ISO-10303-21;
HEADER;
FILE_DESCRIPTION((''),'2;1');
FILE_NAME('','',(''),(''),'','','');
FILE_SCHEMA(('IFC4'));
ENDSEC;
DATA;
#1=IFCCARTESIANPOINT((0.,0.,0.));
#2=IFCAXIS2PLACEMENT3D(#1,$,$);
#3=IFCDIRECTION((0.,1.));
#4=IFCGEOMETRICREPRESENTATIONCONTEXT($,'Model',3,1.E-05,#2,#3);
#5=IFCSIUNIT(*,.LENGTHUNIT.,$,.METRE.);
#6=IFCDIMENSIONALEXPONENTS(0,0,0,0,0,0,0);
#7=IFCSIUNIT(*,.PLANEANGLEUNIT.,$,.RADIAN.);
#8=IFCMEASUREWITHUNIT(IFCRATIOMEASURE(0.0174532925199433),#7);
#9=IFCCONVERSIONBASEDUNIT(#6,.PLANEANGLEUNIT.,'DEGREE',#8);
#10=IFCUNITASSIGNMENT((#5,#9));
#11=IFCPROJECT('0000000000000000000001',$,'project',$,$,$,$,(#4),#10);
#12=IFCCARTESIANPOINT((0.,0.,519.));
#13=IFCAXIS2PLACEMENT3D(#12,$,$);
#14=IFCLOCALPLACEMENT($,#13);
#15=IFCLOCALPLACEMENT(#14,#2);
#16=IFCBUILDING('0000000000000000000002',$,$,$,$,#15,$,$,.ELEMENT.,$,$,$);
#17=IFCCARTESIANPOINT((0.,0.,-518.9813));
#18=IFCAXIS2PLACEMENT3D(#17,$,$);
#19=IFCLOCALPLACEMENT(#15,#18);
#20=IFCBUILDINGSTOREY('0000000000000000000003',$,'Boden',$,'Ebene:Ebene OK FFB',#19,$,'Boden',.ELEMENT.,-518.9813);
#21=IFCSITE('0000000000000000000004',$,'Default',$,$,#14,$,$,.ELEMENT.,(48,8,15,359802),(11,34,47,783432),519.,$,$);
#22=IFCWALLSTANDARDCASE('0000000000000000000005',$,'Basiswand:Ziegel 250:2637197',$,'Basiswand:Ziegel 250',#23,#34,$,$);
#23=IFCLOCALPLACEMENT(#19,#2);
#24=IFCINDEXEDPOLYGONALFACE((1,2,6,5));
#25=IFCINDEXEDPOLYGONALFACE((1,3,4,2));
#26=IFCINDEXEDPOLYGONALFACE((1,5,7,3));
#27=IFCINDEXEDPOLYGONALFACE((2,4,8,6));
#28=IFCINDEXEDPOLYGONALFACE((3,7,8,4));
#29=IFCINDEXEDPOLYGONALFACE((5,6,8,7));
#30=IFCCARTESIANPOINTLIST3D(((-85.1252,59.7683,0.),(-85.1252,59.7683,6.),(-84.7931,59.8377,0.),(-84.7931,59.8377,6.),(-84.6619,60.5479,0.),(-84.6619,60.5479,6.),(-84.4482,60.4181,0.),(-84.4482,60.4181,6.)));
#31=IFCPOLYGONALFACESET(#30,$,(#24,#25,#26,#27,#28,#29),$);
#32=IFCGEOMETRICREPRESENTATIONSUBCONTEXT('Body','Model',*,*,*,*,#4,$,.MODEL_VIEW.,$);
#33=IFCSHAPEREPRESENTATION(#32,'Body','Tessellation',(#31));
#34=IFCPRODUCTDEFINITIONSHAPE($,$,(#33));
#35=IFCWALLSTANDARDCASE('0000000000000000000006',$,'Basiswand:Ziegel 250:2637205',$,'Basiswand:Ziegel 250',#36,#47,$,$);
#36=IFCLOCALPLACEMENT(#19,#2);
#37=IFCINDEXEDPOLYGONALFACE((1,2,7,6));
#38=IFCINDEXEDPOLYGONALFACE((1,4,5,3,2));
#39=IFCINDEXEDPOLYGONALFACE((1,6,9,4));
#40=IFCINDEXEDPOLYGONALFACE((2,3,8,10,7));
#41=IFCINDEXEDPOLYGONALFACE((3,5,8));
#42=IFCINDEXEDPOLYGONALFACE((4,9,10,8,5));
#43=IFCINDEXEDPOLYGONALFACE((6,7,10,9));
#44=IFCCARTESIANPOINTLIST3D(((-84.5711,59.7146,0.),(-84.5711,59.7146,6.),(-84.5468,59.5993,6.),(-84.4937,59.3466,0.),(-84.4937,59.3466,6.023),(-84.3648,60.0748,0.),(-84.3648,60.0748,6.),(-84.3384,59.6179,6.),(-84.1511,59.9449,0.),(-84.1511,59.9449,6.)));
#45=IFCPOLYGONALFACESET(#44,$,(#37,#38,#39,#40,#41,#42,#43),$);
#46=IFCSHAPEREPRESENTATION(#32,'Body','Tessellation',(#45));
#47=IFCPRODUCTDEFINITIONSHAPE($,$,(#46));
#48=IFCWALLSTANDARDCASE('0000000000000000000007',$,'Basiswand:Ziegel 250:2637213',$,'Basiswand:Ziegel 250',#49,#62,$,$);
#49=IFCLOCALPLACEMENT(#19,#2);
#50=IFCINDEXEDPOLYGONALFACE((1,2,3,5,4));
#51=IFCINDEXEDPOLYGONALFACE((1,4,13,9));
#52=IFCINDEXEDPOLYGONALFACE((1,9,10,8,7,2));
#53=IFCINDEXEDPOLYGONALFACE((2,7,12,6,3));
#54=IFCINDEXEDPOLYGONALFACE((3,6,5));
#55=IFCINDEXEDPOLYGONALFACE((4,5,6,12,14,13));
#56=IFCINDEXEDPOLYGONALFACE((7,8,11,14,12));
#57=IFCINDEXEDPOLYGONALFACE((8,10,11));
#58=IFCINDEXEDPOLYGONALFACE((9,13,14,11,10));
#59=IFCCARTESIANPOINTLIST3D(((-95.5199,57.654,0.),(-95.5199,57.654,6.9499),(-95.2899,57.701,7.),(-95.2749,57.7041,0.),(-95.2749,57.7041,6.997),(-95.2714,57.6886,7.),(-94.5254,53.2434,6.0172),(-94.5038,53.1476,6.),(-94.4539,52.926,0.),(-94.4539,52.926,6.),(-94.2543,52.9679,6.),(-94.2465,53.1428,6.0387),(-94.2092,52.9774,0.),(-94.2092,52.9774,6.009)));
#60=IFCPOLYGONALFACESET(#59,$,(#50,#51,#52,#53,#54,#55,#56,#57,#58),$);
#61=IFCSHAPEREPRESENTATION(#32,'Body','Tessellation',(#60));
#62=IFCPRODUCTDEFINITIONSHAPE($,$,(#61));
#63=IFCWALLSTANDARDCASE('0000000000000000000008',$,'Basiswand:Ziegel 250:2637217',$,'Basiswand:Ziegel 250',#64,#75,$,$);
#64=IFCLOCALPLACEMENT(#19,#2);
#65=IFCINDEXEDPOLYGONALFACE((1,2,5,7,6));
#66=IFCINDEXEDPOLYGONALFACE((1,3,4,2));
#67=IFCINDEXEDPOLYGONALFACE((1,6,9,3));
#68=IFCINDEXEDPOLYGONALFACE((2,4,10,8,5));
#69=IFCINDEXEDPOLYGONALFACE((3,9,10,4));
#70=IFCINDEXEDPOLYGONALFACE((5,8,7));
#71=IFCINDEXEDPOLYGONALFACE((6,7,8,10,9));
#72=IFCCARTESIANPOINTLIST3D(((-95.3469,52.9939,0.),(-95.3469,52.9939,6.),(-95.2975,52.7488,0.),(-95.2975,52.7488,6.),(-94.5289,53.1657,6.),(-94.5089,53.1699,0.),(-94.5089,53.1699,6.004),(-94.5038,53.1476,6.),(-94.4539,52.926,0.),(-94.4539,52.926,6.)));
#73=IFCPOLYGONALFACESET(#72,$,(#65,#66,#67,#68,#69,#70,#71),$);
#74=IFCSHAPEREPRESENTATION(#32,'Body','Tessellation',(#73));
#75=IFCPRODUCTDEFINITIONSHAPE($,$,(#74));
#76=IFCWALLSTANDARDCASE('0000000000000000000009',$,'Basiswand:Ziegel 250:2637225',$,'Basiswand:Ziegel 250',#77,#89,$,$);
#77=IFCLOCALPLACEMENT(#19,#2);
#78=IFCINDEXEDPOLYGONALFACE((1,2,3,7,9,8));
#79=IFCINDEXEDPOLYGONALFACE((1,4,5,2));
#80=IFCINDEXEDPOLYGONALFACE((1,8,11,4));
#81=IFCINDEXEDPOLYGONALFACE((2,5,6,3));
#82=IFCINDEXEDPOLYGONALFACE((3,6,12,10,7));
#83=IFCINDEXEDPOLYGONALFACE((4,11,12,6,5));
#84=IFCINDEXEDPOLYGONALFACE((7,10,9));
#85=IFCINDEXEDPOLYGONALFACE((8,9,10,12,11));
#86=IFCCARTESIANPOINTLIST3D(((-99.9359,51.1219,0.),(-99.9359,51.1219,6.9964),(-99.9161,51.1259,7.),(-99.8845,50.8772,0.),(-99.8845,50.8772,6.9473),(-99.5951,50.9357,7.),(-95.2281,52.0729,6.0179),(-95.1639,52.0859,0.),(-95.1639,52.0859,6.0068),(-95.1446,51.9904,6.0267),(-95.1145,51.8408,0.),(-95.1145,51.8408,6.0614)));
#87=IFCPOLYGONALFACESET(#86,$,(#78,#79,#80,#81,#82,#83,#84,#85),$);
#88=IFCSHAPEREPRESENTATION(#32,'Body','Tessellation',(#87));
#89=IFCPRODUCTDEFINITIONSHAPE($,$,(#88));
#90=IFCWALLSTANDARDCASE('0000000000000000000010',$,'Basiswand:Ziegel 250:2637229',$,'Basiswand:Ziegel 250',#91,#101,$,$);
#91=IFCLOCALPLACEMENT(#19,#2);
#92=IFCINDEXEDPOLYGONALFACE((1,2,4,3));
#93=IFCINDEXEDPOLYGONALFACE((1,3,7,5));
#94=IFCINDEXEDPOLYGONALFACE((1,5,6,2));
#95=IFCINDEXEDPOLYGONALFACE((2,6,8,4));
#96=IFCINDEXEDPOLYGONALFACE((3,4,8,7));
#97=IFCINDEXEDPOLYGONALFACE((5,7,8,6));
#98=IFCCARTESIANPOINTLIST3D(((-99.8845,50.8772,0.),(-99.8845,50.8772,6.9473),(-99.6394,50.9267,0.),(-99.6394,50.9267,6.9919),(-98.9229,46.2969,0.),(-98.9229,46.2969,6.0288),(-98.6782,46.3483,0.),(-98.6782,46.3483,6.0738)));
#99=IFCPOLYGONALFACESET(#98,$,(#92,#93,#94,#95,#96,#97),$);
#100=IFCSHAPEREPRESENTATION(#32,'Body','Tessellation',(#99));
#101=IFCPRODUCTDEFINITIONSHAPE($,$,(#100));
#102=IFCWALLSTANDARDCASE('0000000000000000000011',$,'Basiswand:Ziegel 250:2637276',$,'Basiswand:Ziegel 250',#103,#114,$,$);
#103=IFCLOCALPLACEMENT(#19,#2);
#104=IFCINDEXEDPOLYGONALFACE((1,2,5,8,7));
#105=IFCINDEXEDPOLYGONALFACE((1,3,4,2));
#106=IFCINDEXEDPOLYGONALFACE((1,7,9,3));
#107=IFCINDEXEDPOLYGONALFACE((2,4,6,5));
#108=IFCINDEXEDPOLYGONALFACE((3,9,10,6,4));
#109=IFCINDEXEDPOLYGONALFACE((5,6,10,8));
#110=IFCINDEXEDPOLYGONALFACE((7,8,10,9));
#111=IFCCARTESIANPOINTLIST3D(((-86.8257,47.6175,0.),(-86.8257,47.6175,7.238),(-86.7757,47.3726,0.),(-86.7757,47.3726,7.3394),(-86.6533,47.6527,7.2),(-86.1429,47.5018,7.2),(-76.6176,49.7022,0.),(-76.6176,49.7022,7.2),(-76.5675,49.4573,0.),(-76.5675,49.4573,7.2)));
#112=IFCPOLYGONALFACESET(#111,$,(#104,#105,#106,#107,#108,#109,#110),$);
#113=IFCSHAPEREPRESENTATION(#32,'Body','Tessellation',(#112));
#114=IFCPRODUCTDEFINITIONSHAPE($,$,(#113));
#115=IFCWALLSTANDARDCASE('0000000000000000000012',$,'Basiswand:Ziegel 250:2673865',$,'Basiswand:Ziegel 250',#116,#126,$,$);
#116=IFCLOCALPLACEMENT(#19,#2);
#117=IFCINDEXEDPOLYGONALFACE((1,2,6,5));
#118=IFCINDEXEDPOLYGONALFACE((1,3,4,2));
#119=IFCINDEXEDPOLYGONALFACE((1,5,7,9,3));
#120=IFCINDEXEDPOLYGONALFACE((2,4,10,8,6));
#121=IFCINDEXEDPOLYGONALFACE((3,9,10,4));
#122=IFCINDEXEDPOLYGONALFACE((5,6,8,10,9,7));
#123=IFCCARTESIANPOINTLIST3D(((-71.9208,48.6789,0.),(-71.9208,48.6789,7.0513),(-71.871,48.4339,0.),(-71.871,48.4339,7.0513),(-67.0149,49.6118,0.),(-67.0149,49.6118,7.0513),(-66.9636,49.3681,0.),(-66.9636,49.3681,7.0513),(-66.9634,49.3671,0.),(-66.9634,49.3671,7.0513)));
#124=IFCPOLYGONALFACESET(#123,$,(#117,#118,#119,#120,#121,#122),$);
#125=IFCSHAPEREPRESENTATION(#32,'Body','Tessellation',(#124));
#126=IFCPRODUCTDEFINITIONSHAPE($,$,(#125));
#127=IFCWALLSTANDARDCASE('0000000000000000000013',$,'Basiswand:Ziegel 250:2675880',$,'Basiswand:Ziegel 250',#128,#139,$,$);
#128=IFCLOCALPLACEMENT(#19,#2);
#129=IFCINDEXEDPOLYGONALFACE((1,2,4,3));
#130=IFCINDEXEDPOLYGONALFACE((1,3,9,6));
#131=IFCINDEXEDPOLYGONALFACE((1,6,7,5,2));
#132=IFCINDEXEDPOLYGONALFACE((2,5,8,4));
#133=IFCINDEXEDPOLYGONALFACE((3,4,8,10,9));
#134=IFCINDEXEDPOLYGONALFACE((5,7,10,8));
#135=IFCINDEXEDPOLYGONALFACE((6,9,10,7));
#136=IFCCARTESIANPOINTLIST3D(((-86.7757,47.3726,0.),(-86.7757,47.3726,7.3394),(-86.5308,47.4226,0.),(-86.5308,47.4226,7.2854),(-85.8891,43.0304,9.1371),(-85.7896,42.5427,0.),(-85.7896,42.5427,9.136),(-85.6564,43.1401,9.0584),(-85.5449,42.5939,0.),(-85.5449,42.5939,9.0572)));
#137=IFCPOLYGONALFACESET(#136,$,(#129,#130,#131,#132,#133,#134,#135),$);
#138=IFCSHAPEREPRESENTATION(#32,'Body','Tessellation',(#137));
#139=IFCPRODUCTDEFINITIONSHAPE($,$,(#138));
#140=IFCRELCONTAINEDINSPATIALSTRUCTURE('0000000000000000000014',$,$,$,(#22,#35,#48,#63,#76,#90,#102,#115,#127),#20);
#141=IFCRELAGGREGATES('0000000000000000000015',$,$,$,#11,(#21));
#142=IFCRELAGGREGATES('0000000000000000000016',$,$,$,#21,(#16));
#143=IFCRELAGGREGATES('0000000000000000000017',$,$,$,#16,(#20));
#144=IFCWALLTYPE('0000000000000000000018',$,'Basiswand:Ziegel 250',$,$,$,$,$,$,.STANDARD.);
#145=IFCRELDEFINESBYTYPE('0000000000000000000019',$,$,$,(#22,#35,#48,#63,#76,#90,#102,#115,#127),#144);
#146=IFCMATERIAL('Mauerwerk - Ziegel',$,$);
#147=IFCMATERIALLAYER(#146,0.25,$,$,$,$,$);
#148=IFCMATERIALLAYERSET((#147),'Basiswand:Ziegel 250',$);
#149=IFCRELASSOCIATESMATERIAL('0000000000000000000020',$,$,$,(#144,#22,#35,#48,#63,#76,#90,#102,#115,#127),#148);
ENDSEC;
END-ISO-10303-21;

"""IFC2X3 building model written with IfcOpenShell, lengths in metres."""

from ifc_helpers import new_model, entity, si_unit, converted_unit, direction, frame, frame_2d, origin, place, context, subcontext, project, spatial, polyline, rectangle, outline, extrude, clip, bounded_halfspace, material, layer, layer_set, layer_usage, type_object, element, save


model = new_model("IFC2X3")

# Units and contexts
model_context = context("Model", 3, precision=1e-05, world=origin(), true_north=direction((0.0, 1.0)))
body_context = subcontext(model_context, "Body", "Model", "MODEL_VIEW")
ifc_project = project(units=[si_unit("LENGTHUNIT", "METRE"), converted_unit("PLANEANGLEUNIT", "DEGREE", entity("IfcRatioMeasure", 0.0174532925199433), si_unit("PLANEANGLEUNIT", "RADIAN"), dimensions=[0, 0, 0, 0, 0, 0, 0])], contexts=[model_context])

# Site, building, storey
site_placement = place(None, frame((0.0, 0.0, 519.0)))
site = spatial("IfcSite", under=ifc_project, at=site_placement, Name="Default", CompositionType="ELEMENT", RefLatitude=(48, 8, 15, 359802), RefLongitude=(11, 34, 47, 783432), RefElevation=519.0)
building_placement = place(site_placement, origin())
building = spatial("IfcBuilding", under=site, at=building_placement, CompositionType="ELEMENT")
storey_placement = place(building_placement, frame((0.0, 0.0, -518.9813)))
storey = spatial("IfcBuildingStorey", under=building, at=storey_placement, Name="Boden", ObjectType="Ebene:Ebene OK FFB", LongName="Boden", CompositionType="ELEMENT", Elevation=-518.9813)

# Walls
ifc_material = material(Name="Mauerwerk - Ziegel")
ifc_layer = layer(ifc_material, 0.25)
ifc_layer_set = layer_set([ifc_layer], Name="Basiswand:Ziegel 250")
wall_type = type_object("IfcWallType", Name="Basiswand:Ziegel 250", PredefinedType="STANDARD", material=ifc_layer_set)
ifc_layer_usage_1 = layer_usage(ifc_layer_set, "AXIS2", "NEGATIVE", 0.125)
wall_1_placement = place(storey_placement, frame((-85.0177, 59.7044, 0.0), z_axis=(0.0, 0.0, 1.0), x_axis=(0.510864, 0.859661, 0.0)))
element("IfcWallStandardCase", 1, at=wall_1_placement, inside=storey, type_object=wall_type, material=ifc_layer_usage_1, Name="Basiswand:Ziegel 250:2637197", ObjectType="Basiswand:Ziegel 250", context=body_context, shape_type="Clipping", body=[
    clip(extrude(outline(polyline([(0.9044, -0.125), (0.9069, 0.125), (0.3393, 0.125), (0.0, 0.125), (0.2293, -0.125), (0.6544, -0.125), (0.9044, -0.125)])), origin(), (0.0, 0.0, 1.0), 6.0), bounded_halfspace(frame((0.2293, -0.125, 6.0), z_axis=(0.0, 0.0, 1.0), x_axis=(0.999869, 0.016163, 0.0)), False, frame((0.2293, -0.125, 6.0)), polyline([(0.0, 0.0), (0.4251, 0.0), (0.6751, 0.0), (0.6776, 0.25), (0.1099, 0.25), (-0.2293, 0.25), (0.0, 0.0)]))),
])
ifc_layer_usage_2 = layer_usage(ifc_layer_set, "AXIS2", "NEGATIVE", 0.125)
wall_2_placement = place(storey_placement, frame((-84.2564, 60.0127, 0.0), z_axis=(0.0, 0.0, 1.0), x_axis=(-0.496903, -0.867806, 0.0)))
element("IfcWallStandardCase", 2, at=wall_2_placement, inside=storey, type_object=wall_type, material=ifc_layer_usage_2, Name="Basiswand:Ziegel 250:2637205", ObjectType="Basiswand:Ziegel 250", context=body_context, shape_type="Clipping", body=[
    clip(clip(extrude(outline(polyline([(0.4151, -0.125), (0.696, 0.125), (0.3199, 0.125), (0.0065, 0.125), (0.0, -0.125), (0.4151, -0.125)])), origin(), (0.0, 0.0, 1.0), 6.023), bounded_halfspace(frame((0.0, -0.125, 6.0), z_axis=(0.0, 0.0, 1.0), x_axis=(-1.0, 0.0, 0.0)), False, frame((0.0, -0.125, 6.0)), polyline([(0.0, 0.0), (0.4151, 0.0), (0.5031, 0.0783), (0.3834, 0.25), (0.3199, 0.25), (0.0065, 0.25), (0.0, 0.0)]))), bounded_halfspace(frame((0.5031, -0.0467, 6.0), z_axis=(-0.073232, -0.051088, 0.996006), x_axis=(0.572148, -0.82015, 0.0)), False, frame((0.5031, -0.0467, 6.0)), polyline([(0.0, 0.0), (0.1929, 0.1717), (-0.1197, 0.1717), (0.0, 0.0)]))),
])
ifc_layer_usage_3 = layer_usage(ifc_layer_set, "AXIS2", "NEGATIVE", 0.125)
wall_3_placement = place(storey_placement, frame((-94.3311, 52.9499, 0.0), z_axis=(0.0, 0.0, 1.0), x_axis=(-0.219944, 0.975512, 0.0)))
element("IfcWallStandardCase", 3, at=wall_3_placement, inside=storey, type_object=wall_type, material=ifc_layer_usage_3, Name="Basiswand:Ziegel 250:2637213", ObjectType="Basiswand:Ziegel 250", context=body_context, shape_type="Clipping", body=[
    clip(clip(clip(clip(extrude(outline(polyline([(4.8453, -0.125), (4.8503, 0.125), (0.2537, 0.125), (0.0037, 0.125), (0.0, -0.125), (4.8453, -0.125)])), origin(), (0.0, 0.0, 1.0), 7.0), bounded_halfspace(frame((0.1695, -0.125, 6.0387), z_axis=(-0.197586, 0.208537, 0.957848), x_axis=(-0.97938, 0.0, -0.202027)), False, frame((0.1695, -0.125, 6.0387)), polyline([(0.0, 0.0), (4.66, 0.0), (4.6761, 0.0153), (4.6808, 0.25), (0.1595, 0.25), (0.0, 0.0)]))), bounded_halfspace(frame((0.2309, 0.125, 6.0), z_axis=(0.0, 0.0, 1.0), x_axis=(0.014742, 0.999891, 0.0)), False, frame((0.2309, 0.125, 6.0)), polyline([(0.0, 0.0), (-0.2272, 0.0), (-0.2302, -0.2039), (0.0, 0.0)]))), bounded_halfspace(frame((0.0, -0.125, 6.009), z_axis=(-0.169513, 0.191391, 0.966765), x_axis=(-0.748596, -0.663026, 0.0)), False, frame((0.0, -0.125, 6.009)), polyline([(0.0, 0.0), (0.1695, 0.0), (0.3291, 0.25), (0.2537, 0.25), (0.2309, 0.25), (0.0007, 0.0461), (0.0, 0.0)]))), bounded_halfspace(frame((4.8295, -0.125, 7.0), z_axis=(0.183684, -0.193866, 0.963679), x_axis=(0.02664, 0.980981, 0.192269)), False, frame((4.8295, -0.125, 7.0)), polyline([(0.0, 0.0), (0.0158, 0.0), (0.0161, 0.0153), (0.0, 0.0)]))),
])
ifc_layer_usage_4 = layer_usage(ifc_layer_set, "AXIS2", "NEGATIVE", 0.125)
wall_4_placement = place(storey_placement, frame((-95.3232, 52.8712, 0.0), z_axis=(0.0, 0.0, 1.0), x_axis=(0.978649, 0.20554, 0.0)))
element("IfcWallStandardCase", 4, at=wall_4_placement, inside=storey, type_object=wall_type, material=ifc_layer_usage_4, Name="Basiswand:Ziegel 250:2637217", ObjectType="Basiswand:Ziegel 250", context=body_context, shape_type="Clipping", body=[
    clip(clip(extrude(outline(polyline([(0.862, -0.125), (0.8583, 0.125), (0.002, 0.125), (0.0, -0.125), (0.25, -0.125), (0.862, -0.125)])), origin(), (0.0, 0.0, 1.0), 6.004), bounded_halfspace(frame((0.0, -0.125, 6.0), z_axis=(0.0, 0.0, 1.0), x_axis=(-1.0, 0.0, 0.0)), False, frame((0.0, -0.125, 6.0)), polyline([(0.0, 0.0), (0.25, 0.0), (0.862, 0.0), (0.8587, 0.2272), (0.8378, 0.25), (0.002, 0.25), (0.0, 0.0)]))), bounded_halfspace(frame((0.8587, 0.1022, 6.0), z_axis=(-0.188871, -0.172316, 0.966765), x_axis=(0.67399, -0.738741, 0.0)), False, frame((0.8587, 0.1022, 6.0)), polyline([(0.0, 0.0), (-0.0003, 0.0228), (-0.0208, 0.0228), (0.0, 0.0)]))),
])
ifc_layer_usage_5 = layer_usage(ifc_layer_set, "AXIS2", "NEGATIVE", 0.125)
wall_5_placement = place(storey_placement, frame((-99.9111, 50.9994, 0.0), z_axis=(0.0, 0.0, 1.0), x_axis=(0.9802, 0.198012, 0.0)))
element("IfcWallStandardCase", 5, at=wall_5_placement, inside=storey, type_object=wall_type, material=ifc_layer_usage_5, Name="Basiswand:Ziegel 250:2637225", ObjectType="Basiswand:Ziegel 250", context=body_context, shape_type="Clipping", body=[
    clip(clip(clip(extrude(outline(polyline([(4.8683, -0.125), (4.8684, 0.125), (0.0, 0.125), (0.0019, -0.125), (0.2519, -0.125), (4.8683, -0.125)])), origin(), (0.0, 0.0, 1.0), 7.0), bounded_halfspace(frame((0.0019, -0.125, 6.9473), z_axis=(-0.172319, -0.19097, 0.966352), x_axis=(0.015273, -0.981427, -0.191226)), False, frame((0.0019, -0.125, 6.9473)), polyline([(0.0, 0.0), (0.25, 0.0), (0.2953, 0.0), (0.0182, 0.25), (-0.0019, 0.25), (0.0, 0.0)]))), bounded_halfspace(frame((4.8684, 0.0275, 6.0267), z_axis=(0.16348, 0.196463, 0.966787), x_axis=(0.556152, -0.827765, 0.074169)), False, frame((4.8684, 0.0275, 6.0267)), polyline([(0.0, 0.0), (0.0, 0.0975), (-0.0655, 0.0975), (0.0, 0.0)]))), bounded_halfspace(frame((0.2972, -0.125, 7.0), z_axis=(0.196323, 0.217572, 0.956096), x_axis=(-0.979562, 0.0, 0.201142)), False, frame((0.2972, -0.125, 7.0)), polyline([(0.0, 0.0), (4.5711, 0.0), (4.5712, 0.1525), (4.5057, 0.25), (-0.2771, 0.25), (0.0, 0.0)]))),
])
ifc_layer_usage_6 = layer_usage(ifc_layer_set, "AXIS2", "NEGATIVE", 0.125)
wall_6_placement = place(storey_placement, frame((-98.8005, 46.3226, 0.0), z_axis=(0.0, 0.0, 1.0), x_axis=(-0.205469, 0.978664, 0.0)))
element("IfcWallStandardCase", 6, at=wall_6_placement, inside=storey, type_object=wall_type, material=ifc_layer_usage_6, Name="Basiswand:Ziegel 250:2637229", ObjectType="Basiswand:Ziegel 250", context=body_context, shape_type="Clipping", body=[
    clip(extrude(outline(polyline([(4.6783, -0.125), (4.6802, 0.125), (0.0, 0.125), (0.0, -0.0364), (0.0, -0.125), (4.6783, -0.125)])), origin(), (0.0, 0.0, 1.0), 6.9919), bounded_halfspace(frame((0.0, -0.125, 6.0738), z_axis=(-0.189653, 0.173768, 0.966352), x_axis=(-0.981515, -0.0078, -0.191226)), False, frame((0.0, -0.125, 6.0738)), polyline([(0.0, 0.0), (4.6783, 0.0), (4.6802, 0.25), (0.0, 0.25), (0.0, 0.0)]))),
])
ifc_layer_usage_7 = layer_usage(ifc_layer_set, "AXIS2", "NEGATIVE", 0.125)
wall_7_placement = place(storey_placement, frame((-86.8007, 47.495, 0.0), z_axis=(0.0, 0.0, 1.0), x_axis=(0.979778, 0.200089, 0.0)))
element("IfcWallStandardCase", 7, at=wall_7_placement, inside=storey, type_object=wall_type, material=ifc_layer_usage_7, Name="Basiswand:Ziegel 250:2637276", ObjectType="Basiswand:Ziegel 250", context=body_context, shape_type="Clipping", body=[
    clip(clip(extrude(rectangle(XDim=10.4189, YDim=0.25, at=frame_2d((5.2094, 0.0), x_axis=(-1.0, 0.0))), origin(), (0.0, 0.0, 1.0), 7.3394), bounded_halfspace(frame((0.0, -0.125, 7.3394), z_axis=(0.196091, 0.368589, 0.908675), x_axis=(-0.000036, -0.926663, 0.375893)), False, frame((0.0, -0.125, 7.3394)), polyline([(0.0, 0.0), (0.25, 0.0), (0.6459, 0.0), (0.176, 0.25), (0.0, 0.25), (0.0, 0.0)]))), bounded_halfspace(frame((0.6459, -0.125, 7.2), z_axis=(0.0, 0.0, 1.0), x_axis=(0.999998, 0.002103, 0.0)), False, frame((0.6459, -0.125, 7.2)), polyline([(0.0, 0.0), (9.773, 0.0), (9.773, 0.25), (-0.4699, 0.25), (0.0, 0.0)]))),
])
ifc_layer_usage_8 = layer_usage(ifc_layer_set, "AXIS2", "POSITIVE", -0.125)
wall_8_placement = place(storey_placement, frame((-71.8975, 48.5561, 0.0), z_axis=(0.0, 0.0, 1.0), x_axis=(0.982397, 0.186804, 0.0)))
element("IfcWallStandardCase", 8, at=wall_8_placement, inside=storey, type_object=wall_type, material=ifc_layer_usage_8, Name="Basiswand:Ziegel 250:2673865", ObjectType="Basiswand:Ziegel 250", context=body_context, shape_type="SweptSolid", body=[
    extrude(outline(polyline([(4.9987, -0.125), (4.9987, -0.124), (4.9938, 0.125), (0.0, 0.125), (0.0032, -0.125), (4.9987, -0.125)])), origin(), (0.0, 0.0, 1.0), 7.0513),
])
ifc_layer_usage_9 = layer_usage(ifc_layer_set, "AXIS2", "NEGATIVE", 0.125)
wall_9_placement = place(storey_placement, frame((-86.6532, 47.3976, 0.0), z_axis=(0.0, 0.0, 1.0), x_axis=(0.200051, -0.979786, 0.0)))
element("IfcWallStandardCase", 9, at=wall_9_placement, inside=storey, type_object=wall_type, material=ifc_layer_usage_9, Name="Basiswand:Ziegel 250:2675880", ObjectType="Basiswand:Ziegel 250", context=body_context, shape_type="Clipping", body=[
    clip(clip(extrude(outline(polyline([(4.9295, -0.125), (4.9283, 0.125), (0.0, 0.125), (0.0, -0.125), (4.6795, -0.125), (4.9295, -0.125)])), origin(), (0.0, 0.0, 1.0), 9.1371), bounded_halfspace(frame((4.4318, -0.125, 9.1371), z_axis=(0.002171, 0.300558, 0.953761), x_axis=(0.999974, -0.007225, 0.0)), False, frame((4.4318, -0.125, 9.1371)), polyline([(0.0, 0.0), (0.2477, 0.0), (0.4977, 0.0), (0.4965, 0.25), (-0.0609, 0.25), (0.0, 0.0)]))), bounded_halfspace(frame((0.0, -0.125, 7.3394), z_axis=(-0.368596, 0.196077, 0.908675), x_axis=(0.926663, 0.0, 0.375893)), False, frame((0.0, -0.125, 7.3394)), polyline([(0.0, 0.0), (4.4318, 0.0), (4.3709, 0.25), (0.0, 0.25), (0.0, 0.0)]))),
])

save(model, "model.ifc")
